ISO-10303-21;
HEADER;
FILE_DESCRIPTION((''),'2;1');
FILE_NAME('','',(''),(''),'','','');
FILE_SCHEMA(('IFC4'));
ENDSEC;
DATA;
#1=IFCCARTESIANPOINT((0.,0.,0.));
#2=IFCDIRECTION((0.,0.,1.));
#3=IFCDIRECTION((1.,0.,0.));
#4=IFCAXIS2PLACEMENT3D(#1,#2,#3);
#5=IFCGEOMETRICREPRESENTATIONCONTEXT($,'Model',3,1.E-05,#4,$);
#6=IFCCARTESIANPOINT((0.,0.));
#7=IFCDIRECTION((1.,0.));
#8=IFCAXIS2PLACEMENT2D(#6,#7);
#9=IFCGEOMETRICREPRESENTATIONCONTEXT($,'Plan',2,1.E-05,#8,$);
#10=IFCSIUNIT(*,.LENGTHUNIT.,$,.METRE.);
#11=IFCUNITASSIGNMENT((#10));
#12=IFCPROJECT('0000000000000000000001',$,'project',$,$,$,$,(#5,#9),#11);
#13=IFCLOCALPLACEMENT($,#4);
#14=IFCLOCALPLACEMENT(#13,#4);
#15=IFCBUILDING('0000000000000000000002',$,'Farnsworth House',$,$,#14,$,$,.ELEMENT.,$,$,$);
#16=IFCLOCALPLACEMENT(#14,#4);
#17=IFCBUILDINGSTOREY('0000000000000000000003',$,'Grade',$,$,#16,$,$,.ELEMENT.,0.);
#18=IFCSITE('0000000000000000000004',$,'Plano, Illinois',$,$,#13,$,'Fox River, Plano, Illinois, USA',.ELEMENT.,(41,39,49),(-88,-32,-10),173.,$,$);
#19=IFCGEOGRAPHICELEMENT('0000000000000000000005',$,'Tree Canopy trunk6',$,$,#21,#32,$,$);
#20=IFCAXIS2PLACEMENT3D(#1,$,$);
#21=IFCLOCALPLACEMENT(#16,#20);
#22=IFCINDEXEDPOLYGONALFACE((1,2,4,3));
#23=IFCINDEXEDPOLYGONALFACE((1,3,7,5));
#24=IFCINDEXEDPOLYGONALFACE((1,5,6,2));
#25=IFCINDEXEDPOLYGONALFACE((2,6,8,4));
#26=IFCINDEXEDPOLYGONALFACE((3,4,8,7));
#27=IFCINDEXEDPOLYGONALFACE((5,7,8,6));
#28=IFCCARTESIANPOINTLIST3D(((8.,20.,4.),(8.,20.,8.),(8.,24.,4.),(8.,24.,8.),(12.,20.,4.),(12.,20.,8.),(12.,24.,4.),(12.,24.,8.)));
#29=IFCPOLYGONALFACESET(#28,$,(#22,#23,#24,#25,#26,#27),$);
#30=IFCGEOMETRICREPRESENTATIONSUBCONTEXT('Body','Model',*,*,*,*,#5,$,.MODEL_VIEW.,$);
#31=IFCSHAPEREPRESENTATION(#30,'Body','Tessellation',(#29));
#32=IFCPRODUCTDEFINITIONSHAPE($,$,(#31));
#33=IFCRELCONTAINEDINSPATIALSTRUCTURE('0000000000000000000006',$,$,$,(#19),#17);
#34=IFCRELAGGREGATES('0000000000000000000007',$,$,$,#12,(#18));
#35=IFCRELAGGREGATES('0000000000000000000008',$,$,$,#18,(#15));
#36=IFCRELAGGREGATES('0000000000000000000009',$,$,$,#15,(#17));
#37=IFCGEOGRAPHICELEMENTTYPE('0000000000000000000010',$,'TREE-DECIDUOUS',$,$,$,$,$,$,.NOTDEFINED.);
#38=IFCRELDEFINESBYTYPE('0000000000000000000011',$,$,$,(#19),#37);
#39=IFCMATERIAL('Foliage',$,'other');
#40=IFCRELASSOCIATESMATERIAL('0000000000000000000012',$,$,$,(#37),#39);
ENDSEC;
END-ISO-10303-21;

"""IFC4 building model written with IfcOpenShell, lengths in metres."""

from ifc_helpers import new_model, si_unit, frame, origin_with_axes, origin_2d_with_axis, place, context, subcontext, project, spatial, rectangle, extrude, material, type_object, element, save


model = new_model("IFC4")

# Units and contexts
model_context = context("Model", 3, precision=1e-05, world=origin_with_axes())
plan_context = context("Plan", 2, precision=1e-05, world=origin_2d_with_axis())
body_context = subcontext(model_context, "Body", "Model", "MODEL_VIEW")
ifc_project = project(units=[si_unit("LENGTHUNIT", "METRE")], contexts=[model_context, plan_context])

# Site, building, storey
site_placement = place(None, origin_with_axes())
site = spatial("IfcSite", under=ifc_project, at=site_placement, Name="Plano, Illinois", LongName="Fox River, Plano, Illinois, USA", CompositionType="ELEMENT", RefLatitude=(41, 39, 49), RefLongitude=(-88, -32, -10), RefElevation=173.0)
building_placement = place(site_placement, origin_with_axes())
building = spatial("IfcBuilding", under=site, at=building_placement, Name="Farnsworth House", CompositionType="ELEMENT")
storey_placement = place(building_placement, origin_with_axes())
storey = spatial("IfcBuildingStorey", under=building, at=storey_placement, Name="Grade", CompositionType="ELEMENT", Elevation=0.0)

# Geographic element
ifc_material_1 = material(Name="Foliage", Category="other")
geographic_element_type = type_object("IfcGeographicElementType", Name="TREE-DECIDUOUS", PredefinedType="NOTDEFINED", material=ifc_material_1)
geographic_element_1_placement = place(storey_placement, frame((8.0, 20.0, 4.0), z_axis=(0.0, 0.0, 1.0), x_axis=(1.0, 0.0, 0.0)))
element("IfcGeographicElement", 1, at=geographic_element_1_placement, inside=storey, type_object=geographic_element_type, Name="Tree Canopy trunk6", context=body_context, shape_type="SweptSolid", body=[
    extrude(rectangle(XDim=4.0, YDim=4.0, at=origin_2d_with_axis()), frame((2.0, 2.0, 0.0), z_axis=(0.0, 0.0, 1.0), x_axis=(1.0, 0.0, 0.0)), (0.0, 0.0, 1.0), 4.0),
])

save(model, "model.ifc")
